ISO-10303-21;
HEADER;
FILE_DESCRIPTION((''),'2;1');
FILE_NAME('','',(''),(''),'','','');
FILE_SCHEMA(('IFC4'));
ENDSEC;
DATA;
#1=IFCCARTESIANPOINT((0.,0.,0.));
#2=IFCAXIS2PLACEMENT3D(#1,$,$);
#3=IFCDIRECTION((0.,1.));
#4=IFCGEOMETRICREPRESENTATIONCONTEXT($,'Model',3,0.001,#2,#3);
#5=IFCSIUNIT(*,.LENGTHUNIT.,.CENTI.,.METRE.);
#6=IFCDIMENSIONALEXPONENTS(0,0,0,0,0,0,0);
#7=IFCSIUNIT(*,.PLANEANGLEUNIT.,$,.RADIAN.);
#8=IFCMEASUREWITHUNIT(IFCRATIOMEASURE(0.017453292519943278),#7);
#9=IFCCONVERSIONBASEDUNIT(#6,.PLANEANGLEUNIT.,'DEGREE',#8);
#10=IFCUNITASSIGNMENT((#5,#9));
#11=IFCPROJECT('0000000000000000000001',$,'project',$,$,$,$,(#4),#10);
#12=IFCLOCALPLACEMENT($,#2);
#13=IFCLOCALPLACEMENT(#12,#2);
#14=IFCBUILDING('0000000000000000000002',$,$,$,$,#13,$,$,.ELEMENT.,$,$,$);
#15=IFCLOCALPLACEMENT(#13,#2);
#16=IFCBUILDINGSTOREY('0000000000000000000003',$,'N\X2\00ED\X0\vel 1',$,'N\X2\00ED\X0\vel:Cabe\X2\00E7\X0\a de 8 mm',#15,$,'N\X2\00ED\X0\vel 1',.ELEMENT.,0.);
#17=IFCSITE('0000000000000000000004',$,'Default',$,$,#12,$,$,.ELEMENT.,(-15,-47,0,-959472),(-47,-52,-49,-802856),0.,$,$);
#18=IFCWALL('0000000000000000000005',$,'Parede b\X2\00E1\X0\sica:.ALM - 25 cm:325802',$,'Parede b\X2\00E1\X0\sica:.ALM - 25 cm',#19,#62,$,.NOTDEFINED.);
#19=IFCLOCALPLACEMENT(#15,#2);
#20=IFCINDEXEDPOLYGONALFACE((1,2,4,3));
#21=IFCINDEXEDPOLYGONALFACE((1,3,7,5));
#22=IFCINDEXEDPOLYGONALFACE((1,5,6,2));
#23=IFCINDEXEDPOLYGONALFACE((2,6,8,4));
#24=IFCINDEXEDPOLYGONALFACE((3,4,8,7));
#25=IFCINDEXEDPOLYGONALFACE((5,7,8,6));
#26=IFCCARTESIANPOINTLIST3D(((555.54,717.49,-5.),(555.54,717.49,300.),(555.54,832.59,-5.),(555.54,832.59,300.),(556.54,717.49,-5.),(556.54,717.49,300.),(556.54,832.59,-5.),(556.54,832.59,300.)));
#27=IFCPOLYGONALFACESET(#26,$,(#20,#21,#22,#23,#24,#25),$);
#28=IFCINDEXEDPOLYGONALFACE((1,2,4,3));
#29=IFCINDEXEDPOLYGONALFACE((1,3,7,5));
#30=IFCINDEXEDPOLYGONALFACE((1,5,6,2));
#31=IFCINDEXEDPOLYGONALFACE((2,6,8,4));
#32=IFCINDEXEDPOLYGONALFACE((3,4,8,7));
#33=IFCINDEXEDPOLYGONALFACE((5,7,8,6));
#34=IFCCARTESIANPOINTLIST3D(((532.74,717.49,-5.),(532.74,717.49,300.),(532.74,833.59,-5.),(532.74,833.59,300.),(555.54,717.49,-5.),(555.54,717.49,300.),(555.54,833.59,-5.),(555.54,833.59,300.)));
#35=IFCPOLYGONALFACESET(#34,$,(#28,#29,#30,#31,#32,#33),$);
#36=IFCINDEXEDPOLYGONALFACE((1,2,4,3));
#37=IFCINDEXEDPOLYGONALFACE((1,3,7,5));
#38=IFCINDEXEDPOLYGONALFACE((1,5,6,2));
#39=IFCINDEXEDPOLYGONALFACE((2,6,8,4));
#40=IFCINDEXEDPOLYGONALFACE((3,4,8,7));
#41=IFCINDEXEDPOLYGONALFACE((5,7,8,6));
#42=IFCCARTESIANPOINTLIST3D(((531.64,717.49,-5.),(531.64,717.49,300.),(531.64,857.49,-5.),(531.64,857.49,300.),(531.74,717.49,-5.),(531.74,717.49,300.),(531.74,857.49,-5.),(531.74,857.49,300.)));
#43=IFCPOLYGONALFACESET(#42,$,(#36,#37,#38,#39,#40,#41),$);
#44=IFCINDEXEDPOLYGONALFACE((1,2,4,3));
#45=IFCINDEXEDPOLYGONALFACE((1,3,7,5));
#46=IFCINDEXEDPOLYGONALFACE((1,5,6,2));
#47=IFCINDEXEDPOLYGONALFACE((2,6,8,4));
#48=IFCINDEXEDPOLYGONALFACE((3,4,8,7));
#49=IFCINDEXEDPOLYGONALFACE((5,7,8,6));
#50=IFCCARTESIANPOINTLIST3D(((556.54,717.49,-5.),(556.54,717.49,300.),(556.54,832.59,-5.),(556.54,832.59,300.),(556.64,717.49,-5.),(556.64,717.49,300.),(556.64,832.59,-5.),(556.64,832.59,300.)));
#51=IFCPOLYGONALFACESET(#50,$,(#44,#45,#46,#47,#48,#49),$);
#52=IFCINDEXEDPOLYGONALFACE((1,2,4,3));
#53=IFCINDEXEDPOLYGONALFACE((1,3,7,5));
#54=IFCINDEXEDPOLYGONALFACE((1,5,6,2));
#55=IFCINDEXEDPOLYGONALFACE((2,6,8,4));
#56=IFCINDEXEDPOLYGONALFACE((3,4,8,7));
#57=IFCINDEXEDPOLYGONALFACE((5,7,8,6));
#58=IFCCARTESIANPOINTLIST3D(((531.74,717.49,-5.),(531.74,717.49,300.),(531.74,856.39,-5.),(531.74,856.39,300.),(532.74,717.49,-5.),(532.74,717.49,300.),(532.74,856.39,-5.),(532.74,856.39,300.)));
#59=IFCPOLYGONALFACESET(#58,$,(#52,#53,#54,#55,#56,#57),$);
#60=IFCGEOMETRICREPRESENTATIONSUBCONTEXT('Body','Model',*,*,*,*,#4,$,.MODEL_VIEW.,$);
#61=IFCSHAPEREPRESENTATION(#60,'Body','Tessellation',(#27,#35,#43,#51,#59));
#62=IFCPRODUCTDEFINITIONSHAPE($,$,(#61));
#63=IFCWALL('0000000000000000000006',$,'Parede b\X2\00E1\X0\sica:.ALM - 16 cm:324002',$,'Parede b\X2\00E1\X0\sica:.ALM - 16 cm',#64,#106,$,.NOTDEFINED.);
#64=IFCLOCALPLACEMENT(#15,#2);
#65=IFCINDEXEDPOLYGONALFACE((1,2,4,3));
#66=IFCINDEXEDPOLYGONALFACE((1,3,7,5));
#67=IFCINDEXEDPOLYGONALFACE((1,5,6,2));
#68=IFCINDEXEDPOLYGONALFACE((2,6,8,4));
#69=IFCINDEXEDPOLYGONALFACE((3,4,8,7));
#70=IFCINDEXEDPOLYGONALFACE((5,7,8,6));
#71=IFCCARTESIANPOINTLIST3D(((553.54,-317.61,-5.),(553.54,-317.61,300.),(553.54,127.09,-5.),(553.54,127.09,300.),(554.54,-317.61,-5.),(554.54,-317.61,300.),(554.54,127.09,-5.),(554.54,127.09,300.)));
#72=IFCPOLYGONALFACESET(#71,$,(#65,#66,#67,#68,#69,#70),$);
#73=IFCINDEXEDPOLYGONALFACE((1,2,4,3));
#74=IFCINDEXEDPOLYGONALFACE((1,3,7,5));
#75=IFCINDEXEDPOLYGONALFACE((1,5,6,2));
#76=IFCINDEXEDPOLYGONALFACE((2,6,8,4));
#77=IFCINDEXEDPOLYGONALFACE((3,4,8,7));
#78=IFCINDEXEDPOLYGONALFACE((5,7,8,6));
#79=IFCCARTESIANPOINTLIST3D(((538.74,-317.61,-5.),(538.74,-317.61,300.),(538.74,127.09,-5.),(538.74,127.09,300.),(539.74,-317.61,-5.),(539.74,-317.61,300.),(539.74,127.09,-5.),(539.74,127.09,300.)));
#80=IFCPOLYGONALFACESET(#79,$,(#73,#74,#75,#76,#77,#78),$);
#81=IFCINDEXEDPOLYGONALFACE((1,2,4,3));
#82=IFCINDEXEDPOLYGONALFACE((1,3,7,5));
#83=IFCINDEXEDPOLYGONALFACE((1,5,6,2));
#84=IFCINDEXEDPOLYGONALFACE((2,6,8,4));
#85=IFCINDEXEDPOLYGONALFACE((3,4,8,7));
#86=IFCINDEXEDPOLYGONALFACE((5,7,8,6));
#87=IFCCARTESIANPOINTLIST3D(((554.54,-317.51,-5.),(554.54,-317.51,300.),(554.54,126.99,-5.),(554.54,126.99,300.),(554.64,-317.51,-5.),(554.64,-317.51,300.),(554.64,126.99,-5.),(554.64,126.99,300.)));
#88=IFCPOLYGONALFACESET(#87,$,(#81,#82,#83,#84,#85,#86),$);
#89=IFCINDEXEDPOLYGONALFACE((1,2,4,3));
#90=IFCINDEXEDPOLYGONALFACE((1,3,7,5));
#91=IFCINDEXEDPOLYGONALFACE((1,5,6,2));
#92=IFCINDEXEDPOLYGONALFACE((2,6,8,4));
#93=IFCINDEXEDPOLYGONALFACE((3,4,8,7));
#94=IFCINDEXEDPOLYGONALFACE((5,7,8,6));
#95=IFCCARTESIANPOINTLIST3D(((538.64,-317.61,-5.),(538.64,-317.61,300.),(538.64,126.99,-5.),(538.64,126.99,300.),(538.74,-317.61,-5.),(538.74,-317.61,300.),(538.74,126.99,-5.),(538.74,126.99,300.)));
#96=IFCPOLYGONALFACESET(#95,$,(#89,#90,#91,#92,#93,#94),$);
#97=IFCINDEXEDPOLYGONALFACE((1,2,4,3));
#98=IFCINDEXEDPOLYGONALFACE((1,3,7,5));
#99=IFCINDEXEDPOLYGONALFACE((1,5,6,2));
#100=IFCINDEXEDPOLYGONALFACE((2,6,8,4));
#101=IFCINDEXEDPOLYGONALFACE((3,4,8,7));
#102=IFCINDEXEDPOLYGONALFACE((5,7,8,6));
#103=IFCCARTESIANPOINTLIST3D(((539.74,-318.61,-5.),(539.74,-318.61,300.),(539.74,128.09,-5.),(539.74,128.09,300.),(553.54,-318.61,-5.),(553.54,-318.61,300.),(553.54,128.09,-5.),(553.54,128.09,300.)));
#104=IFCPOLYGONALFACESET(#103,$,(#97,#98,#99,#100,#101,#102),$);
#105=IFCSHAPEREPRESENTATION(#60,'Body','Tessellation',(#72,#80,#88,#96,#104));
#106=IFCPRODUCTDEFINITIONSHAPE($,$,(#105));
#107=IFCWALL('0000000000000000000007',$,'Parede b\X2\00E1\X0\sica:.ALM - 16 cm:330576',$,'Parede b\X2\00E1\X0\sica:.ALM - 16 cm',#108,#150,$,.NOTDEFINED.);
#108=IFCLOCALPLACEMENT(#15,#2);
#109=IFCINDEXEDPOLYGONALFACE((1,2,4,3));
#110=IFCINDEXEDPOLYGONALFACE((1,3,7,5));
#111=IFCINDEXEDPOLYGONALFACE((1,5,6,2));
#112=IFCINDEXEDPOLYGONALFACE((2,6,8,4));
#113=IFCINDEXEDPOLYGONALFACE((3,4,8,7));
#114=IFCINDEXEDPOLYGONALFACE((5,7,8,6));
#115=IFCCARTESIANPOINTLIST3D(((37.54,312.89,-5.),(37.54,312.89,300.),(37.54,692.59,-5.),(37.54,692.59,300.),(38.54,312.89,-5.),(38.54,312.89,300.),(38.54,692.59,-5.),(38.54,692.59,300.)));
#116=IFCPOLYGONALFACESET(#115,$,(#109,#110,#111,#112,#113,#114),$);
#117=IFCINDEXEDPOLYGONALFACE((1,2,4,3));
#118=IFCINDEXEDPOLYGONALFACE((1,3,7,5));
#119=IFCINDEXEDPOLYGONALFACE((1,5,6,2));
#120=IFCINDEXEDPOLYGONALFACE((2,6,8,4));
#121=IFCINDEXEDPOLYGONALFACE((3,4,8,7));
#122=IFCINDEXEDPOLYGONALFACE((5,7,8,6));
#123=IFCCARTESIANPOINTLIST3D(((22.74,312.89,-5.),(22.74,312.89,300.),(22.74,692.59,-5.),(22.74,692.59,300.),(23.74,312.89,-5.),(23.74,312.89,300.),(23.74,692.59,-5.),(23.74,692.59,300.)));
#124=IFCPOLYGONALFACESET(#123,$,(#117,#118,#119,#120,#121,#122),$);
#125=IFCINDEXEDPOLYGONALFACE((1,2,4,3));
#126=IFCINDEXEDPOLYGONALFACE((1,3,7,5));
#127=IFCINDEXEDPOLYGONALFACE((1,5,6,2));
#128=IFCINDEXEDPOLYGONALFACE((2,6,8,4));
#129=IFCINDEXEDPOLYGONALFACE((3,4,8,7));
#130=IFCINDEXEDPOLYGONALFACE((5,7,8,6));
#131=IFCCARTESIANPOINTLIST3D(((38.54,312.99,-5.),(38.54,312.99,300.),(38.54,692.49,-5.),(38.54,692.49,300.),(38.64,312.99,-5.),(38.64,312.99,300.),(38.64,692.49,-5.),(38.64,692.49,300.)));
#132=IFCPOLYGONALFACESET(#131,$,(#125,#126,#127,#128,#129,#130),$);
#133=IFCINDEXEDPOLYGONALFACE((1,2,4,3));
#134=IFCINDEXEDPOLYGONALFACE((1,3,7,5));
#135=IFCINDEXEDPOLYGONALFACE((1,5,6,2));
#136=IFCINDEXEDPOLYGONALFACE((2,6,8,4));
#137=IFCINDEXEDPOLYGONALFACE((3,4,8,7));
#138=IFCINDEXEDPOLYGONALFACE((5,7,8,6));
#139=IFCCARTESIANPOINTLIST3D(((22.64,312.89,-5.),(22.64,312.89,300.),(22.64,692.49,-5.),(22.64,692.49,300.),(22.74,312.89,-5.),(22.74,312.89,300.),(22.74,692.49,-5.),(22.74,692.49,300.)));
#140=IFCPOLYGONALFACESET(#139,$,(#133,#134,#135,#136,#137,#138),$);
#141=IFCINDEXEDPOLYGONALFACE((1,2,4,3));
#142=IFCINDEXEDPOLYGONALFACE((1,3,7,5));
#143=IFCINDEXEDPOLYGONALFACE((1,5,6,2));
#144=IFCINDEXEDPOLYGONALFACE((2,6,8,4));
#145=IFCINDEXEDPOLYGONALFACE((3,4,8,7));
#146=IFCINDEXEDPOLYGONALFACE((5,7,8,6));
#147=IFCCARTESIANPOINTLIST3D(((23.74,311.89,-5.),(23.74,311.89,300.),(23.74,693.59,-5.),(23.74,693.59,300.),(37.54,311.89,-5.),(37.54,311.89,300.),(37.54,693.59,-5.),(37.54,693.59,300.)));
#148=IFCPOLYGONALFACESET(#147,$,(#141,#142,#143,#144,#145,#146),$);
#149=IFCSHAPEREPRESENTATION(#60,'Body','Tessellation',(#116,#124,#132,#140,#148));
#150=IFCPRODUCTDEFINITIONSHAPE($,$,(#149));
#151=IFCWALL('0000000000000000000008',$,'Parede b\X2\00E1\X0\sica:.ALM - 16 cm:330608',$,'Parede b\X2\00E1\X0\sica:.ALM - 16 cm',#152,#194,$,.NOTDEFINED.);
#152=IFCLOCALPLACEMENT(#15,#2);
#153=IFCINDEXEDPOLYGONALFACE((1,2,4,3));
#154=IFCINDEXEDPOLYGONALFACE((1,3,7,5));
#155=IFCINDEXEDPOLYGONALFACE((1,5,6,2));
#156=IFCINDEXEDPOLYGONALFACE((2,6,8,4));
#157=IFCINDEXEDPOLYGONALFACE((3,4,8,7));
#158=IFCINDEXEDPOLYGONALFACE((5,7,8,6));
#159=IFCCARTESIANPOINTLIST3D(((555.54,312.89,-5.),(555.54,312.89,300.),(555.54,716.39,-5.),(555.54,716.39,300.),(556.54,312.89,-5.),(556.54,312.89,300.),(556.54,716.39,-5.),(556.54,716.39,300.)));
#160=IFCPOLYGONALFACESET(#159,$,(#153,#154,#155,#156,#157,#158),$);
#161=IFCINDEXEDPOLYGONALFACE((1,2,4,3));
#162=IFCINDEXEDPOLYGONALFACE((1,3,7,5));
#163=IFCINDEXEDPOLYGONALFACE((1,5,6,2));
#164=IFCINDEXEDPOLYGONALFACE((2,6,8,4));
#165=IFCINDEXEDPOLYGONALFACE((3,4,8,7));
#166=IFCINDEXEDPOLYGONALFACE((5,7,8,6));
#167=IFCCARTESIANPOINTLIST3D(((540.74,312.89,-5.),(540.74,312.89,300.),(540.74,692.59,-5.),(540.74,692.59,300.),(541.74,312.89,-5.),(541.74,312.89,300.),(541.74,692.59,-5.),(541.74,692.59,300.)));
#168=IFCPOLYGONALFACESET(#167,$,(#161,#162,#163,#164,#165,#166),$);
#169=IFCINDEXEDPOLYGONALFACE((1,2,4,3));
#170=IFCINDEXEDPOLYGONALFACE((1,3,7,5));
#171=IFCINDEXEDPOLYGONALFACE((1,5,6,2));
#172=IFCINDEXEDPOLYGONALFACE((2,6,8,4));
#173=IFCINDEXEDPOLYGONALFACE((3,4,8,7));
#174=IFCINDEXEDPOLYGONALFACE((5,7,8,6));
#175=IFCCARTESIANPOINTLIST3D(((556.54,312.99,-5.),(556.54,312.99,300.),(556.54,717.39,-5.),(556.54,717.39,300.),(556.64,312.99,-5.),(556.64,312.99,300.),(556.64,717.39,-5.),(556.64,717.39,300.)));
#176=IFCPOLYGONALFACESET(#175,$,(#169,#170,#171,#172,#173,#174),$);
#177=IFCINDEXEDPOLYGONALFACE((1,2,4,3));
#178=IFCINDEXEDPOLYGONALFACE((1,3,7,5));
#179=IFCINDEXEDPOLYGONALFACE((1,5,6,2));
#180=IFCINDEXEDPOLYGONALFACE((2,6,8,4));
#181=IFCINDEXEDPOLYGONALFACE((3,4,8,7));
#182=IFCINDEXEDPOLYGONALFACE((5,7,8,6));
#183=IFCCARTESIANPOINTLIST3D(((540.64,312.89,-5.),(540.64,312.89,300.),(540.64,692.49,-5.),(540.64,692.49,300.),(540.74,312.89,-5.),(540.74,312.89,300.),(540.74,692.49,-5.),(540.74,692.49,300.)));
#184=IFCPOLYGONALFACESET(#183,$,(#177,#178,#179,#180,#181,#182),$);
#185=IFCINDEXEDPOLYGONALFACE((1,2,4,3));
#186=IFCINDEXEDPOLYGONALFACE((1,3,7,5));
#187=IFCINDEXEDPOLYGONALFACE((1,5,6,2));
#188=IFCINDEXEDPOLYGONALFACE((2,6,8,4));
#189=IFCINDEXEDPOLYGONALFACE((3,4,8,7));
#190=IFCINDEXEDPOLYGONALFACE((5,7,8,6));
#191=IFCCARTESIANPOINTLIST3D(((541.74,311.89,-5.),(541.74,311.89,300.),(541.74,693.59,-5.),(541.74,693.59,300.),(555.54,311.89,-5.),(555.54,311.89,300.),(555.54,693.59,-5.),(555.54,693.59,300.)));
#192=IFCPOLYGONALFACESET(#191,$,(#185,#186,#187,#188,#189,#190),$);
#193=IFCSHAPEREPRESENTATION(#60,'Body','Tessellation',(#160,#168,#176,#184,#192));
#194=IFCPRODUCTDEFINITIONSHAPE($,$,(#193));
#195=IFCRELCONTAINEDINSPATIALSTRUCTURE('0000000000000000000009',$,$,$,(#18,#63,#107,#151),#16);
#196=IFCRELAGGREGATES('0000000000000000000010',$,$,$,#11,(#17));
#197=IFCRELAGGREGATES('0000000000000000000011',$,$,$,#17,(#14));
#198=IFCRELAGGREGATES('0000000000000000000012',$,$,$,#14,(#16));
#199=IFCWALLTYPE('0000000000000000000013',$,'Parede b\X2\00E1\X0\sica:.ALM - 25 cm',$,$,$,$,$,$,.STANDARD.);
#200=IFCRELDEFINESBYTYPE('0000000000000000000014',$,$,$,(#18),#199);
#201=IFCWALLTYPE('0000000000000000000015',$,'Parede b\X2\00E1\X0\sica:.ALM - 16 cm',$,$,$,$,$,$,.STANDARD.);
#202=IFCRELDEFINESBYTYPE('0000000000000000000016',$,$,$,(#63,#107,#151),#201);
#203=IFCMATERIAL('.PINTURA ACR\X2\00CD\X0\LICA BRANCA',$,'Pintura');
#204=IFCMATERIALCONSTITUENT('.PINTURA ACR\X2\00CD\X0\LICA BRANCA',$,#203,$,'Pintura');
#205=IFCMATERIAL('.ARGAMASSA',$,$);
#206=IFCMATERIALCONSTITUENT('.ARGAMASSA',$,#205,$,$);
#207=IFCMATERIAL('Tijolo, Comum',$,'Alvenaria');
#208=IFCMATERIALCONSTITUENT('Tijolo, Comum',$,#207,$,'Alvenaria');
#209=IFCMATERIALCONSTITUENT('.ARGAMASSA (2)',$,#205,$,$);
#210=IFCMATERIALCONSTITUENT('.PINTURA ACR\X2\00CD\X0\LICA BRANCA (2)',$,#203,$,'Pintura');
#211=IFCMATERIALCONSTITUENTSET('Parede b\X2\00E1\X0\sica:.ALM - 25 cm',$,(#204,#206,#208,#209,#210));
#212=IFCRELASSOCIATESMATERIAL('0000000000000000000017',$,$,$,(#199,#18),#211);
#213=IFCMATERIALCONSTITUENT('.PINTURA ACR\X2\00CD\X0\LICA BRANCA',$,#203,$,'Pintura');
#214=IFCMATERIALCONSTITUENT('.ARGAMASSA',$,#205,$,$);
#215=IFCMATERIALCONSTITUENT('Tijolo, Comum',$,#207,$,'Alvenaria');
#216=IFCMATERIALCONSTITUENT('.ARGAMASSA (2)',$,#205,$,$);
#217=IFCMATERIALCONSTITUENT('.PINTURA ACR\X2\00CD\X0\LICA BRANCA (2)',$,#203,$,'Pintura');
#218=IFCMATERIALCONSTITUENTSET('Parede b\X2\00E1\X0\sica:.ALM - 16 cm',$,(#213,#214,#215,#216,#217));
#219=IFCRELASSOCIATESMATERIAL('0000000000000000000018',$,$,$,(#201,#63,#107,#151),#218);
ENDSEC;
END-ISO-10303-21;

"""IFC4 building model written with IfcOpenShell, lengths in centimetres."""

from ifc_helpers import new_model, entity, si_unit, converted_unit, direction, frame, origin, place, context, subcontext, project, spatial, indexed_curve, outline, extrude, material, constituent, constituent_set, type_object, element, save


model = new_model("IFC4")

# Units and contexts
model_context = context("Model", 3, precision=0.001, world=origin(), true_north=direction((0.0, 1.0)))
body_context = subcontext(model_context, "Body", "Model", "MODEL_VIEW")
ifc_project = project(units=[si_unit("LENGTHUNIT", "METRE", prefix="CENTI"), converted_unit("PLANEANGLEUNIT", "DEGREE", entity("IfcRatioMeasure", 0.017453292519943278), si_unit("PLANEANGLEUNIT", "RADIAN"), dimensions=[0, 0, 0, 0, 0, 0, 0])], contexts=[model_context])

# Site, building, storey
site_placement = place(None, origin())
site = spatial("IfcSite", under=ifc_project, at=site_placement, Name="Default", CompositionType="ELEMENT", RefLatitude=(-15, -47, 0, -959472), RefLongitude=(-47, -52, -49, -802856), RefElevation=0.0)
building_placement = place(site_placement, origin())
building = spatial("IfcBuilding", under=site, at=building_placement, CompositionType="ELEMENT")
storey_placement = place(building_placement, origin())
storey = spatial("IfcBuildingStorey", under=building, at=storey_placement, Name="Nível 1", ObjectType="Nível:Cabeça de 8 mm", LongName="Nível 1", CompositionType="ELEMENT", Elevation=0.0)

# Shared definitions
ifc_material_1 = material(Name=".PINTURA ACRÍLICA BRANCA", Category="Pintura")
ifc_constituent_1 = constituent(ifc_material_1, Name=".PINTURA ACRÍLICA BRANCA", Category="Pintura")
ifc_material_2 = material(Name=".ARGAMASSA")
ifc_constituent_2 = constituent(ifc_material_2, Name=".ARGAMASSA")
ifc_material_3 = material(Name="Tijolo, Comum", Category="Alvenaria")
ifc_constituent_3 = constituent(ifc_material_3, Name="Tijolo, Comum", Category="Alvenaria")
ifc_constituent_4 = constituent(ifc_material_2, Name=".ARGAMASSA (2)")
ifc_constituent_5 = constituent(ifc_material_1, Name=".PINTURA ACRÍLICA BRANCA (2)", Category="Pintura")
ifc_constituent_set_1 = constituent_set(constituents=[ifc_constituent_1, ifc_constituent_2, ifc_constituent_3, ifc_constituent_4, ifc_constituent_5], Name="Parede básica:.ALM - 25 cm")
wall_type_1 = type_object("IfcWallType", Name="Parede básica:.ALM - 25 cm", PredefinedType="STANDARD", material=ifc_constituent_set_1)

# Wall
wall_1_placement = place(storey_placement, frame((544.14, 717.49, -5.0), z_axis=(0.0, 0.0, 1.0), x_axis=(0.0, 1.0, 0.0)))
element("IfcWall", 1, at=wall_1_placement, inside=storey, type_object=wall_type_1, material=ifc_constituent_set_1, Name="Parede básica:.ALM - 25 cm:325802", ObjectType="Parede básica:.ALM - 25 cm", PredefinedType="NOTDEFINED", context=body_context, shape_type="SweptSolid", body=[
    extrude(outline(indexed_curve([(-57.55, -0.5), (57.55, -0.5), (57.55, 0.5), (-57.55, 0.5), (-57.55, -0.5)], self_intersect=False)), frame((57.55, -11.9, 0.0)), (0.0, 0.0, 1.0), 305.0),
    extrude(outline(indexed_curve([(-58.05, -11.4), (58.05, -11.4), (58.05, 11.4), (-58.05, 11.4), (-58.05, -11.4)], self_intersect=False)), frame((58.05, 0.0, 0.0)), (0.0, 0.0, 1.0), 305.0),
    extrude(outline(indexed_curve([(-0.05, -70.0), (0.05, -70.0), (0.05, 70.0), (-0.05, 70.0), (-0.05, -70.0)], self_intersect=False)), frame((70.0, 12.45, 0.0), z_axis=(0.0, 0.0, 1.0), x_axis=(0.0, -1.0, 0.0)), (0.0, 0.0, 1.0), 305.0),
    extrude(outline(indexed_curve([(-0.05, -57.55), (0.05, -57.55), (0.05, 57.55), (-0.05, 57.55), (-0.05, -57.55)], self_intersect=False)), frame((57.55, -12.45, 0.0), z_axis=(0.0, 0.0, 1.0), x_axis=(0.0, 1.0, 0.0)), (0.0, 0.0, 1.0), 305.0),
    extrude(outline(indexed_curve([(-69.45, -0.5), (69.45, -0.5), (69.45, 0.5), (-69.45, 0.5), (-69.45, -0.5)], self_intersect=False)), frame((69.45, 11.9, 0.0)), (0.0, 0.0, 1.0), 305.0),
])

# Shared definitions
ifc_constituent_6 = constituent(ifc_material_1, Name=".PINTURA ACRÍLICA BRANCA", Category="Pintura")
ifc_constituent_7 = constituent(ifc_material_2, Name=".ARGAMASSA")
ifc_constituent_8 = constituent(ifc_material_3, Name="Tijolo, Comum", Category="Alvenaria")
ifc_constituent_9 = constituent(ifc_material_2, Name=".ARGAMASSA (2)")
ifc_constituent_10 = constituent(ifc_material_1, Name=".PINTURA ACRÍLICA BRANCA (2)", Category="Pintura")
ifc_constituent_set_2 = constituent_set(constituents=[ifc_constituent_6, ifc_constituent_7, ifc_constituent_8, ifc_constituent_9, ifc_constituent_10], Name="Parede básica:.ALM - 16 cm")
wall_type_2 = type_object("IfcWallType", Name="Parede básica:.ALM - 16 cm", PredefinedType="STANDARD", material=ifc_constituent_set_2)

# Wall
wall_2_placement = place(storey_placement, frame((546.64, -317.51, -5.0), z_axis=(0.0, 0.0, 1.0), x_axis=(0.0, 1.0, 0.0)))
element("IfcWall", 2, at=wall_2_placement, inside=storey, type_object=wall_type_2, material=ifc_constituent_set_2, Name="Parede básica:.ALM - 16 cm:324002", ObjectType="Parede básica:.ALM - 16 cm", PredefinedType="NOTDEFINED", context=body_context, shape_type="SweptSolid", body=[
    extrude(outline(indexed_curve([(-222.35, -0.5), (222.35, -0.5), (222.35, 0.5), (-222.35, 0.5), (-222.35, -0.5)], self_intersect=False)), frame((222.25, -7.4, 0.0)), (0.0, 0.0, 1.0), 305.0),
    extrude(outline(indexed_curve([(-222.35, -0.5), (222.35, -0.5), (222.35, 0.5), (-222.35, 0.5), (-222.35, -0.5)], self_intersect=False)), frame((222.25, 7.4, 0.0)), (0.0, 0.0, 1.0), 305.0),
    extrude(outline(indexed_curve([(-0.05, -222.25), (0.05, -222.25), (0.05, 222.25), (-0.05, 222.25), (-0.05, -222.25)], self_intersect=False)), frame((222.25, -7.95, 0.0), z_axis=(0.0, 0.0, 1.0), x_axis=(0.0, 1.0, 0.0)), (0.0, 0.0, 1.0), 305.0),
    extrude(outline(indexed_curve([(-0.05, -222.3), (0.05, -222.3), (0.05, 222.3), (-0.05, 222.3), (-0.05, -222.3)], self_intersect=False)), frame((222.2, 7.95, 0.0), z_axis=(0.0, 0.0, 1.0), x_axis=(0.0, -1.0, 0.0)), (0.0, 0.0, 1.0), 305.0),
    extrude(outline(indexed_curve([(-223.35, -6.9), (223.35, -6.9), (223.35, 6.9), (-223.35, 6.9), (-223.35, -6.9)], self_intersect=False)), frame((222.25, 0.0, 0.0)), (0.0, 0.0, 1.0), 305.0),
])

# Walls
wall_3_placement = place(storey_placement, frame((30.64, 312.99, -5.0), z_axis=(0.0, 0.0, 1.0), x_axis=(0.0, 1.0, 0.0)))
element("IfcWall", 3, at=wall_3_placement, inside=storey, type_object=wall_type_2, material=ifc_constituent_set_2, Name="Parede básica:.ALM - 16 cm:330576", ObjectType="Parede básica:.ALM - 16 cm", PredefinedType="NOTDEFINED", context=body_context, shape_type="SweptSolid", body=[
    extrude(outline(indexed_curve([(-189.85, -0.5), (189.85, -0.5), (189.85, 0.5), (-189.85, 0.5), (-189.85, -0.5)], self_intersect=False)), frame((189.75, -7.4, 0.0)), (0.0, 0.0, 1.0), 305.0),
    extrude(outline(indexed_curve([(-189.85, -0.5), (189.85, -0.5), (189.85, 0.5), (-189.85, 0.5), (-189.85, -0.5)], self_intersect=False)), frame((189.75, 7.4, 0.0)), (0.0, 0.0, 1.0), 305.0),
    extrude(outline(indexed_curve([(-0.05, -189.75), (0.05, -189.75), (0.05, 189.75), (-0.05, 189.75), (-0.05, -189.75)], self_intersect=False)), frame((189.75, -7.95, 0.0), z_axis=(0.0, 0.0, 1.0), x_axis=(0.0, 1.0, 0.0)), (0.0, 0.0, 1.0), 305.0),
    extrude(outline(indexed_curve([(-0.05, -189.8), (0.05, -189.8), (0.05, 189.8), (-0.05, 189.8), (-0.05, -189.8)], self_intersect=False)), frame((189.7, 7.95, 0.0), z_axis=(0.0, 0.0, 1.0), x_axis=(0.0, -1.0, 0.0)), (0.0, 0.0, 1.0), 305.0),
    extrude(outline(indexed_curve([(-190.85, -6.9), (190.85, -6.9), (190.85, 6.9), (-190.85, 6.9), (-190.85, -6.9)], self_intersect=False)), frame((189.75, 0.0, 0.0)), (0.0, 0.0, 1.0), 305.0),
])
wall_4_placement = place(storey_placement, frame((548.64, 312.99, -5.0), z_axis=(0.0, 0.0, 1.0), x_axis=(0.0, 1.0, 0.0)))
element("IfcWall", 4, at=wall_4_placement, inside=storey, type_object=wall_type_2, material=ifc_constituent_set_2, Name="Parede básica:.ALM - 16 cm:330608", ObjectType="Parede básica:.ALM - 16 cm", PredefinedType="NOTDEFINED", context=body_context, shape_type="SweptSolid", body=[
    extrude(outline(indexed_curve([(-201.75, -0.5), (201.75, -0.5), (201.75, 0.5), (-201.75, 0.5), (-201.75, -0.5)], self_intersect=False)), frame((201.65, -7.4, 0.0)), (0.0, 0.0, 1.0), 305.0),
    extrude(outline(indexed_curve([(-189.85, -0.5), (189.85, -0.5), (189.85, 0.5), (-189.85, 0.5), (-189.85, -0.5)], self_intersect=False)), frame((189.75, 7.4, 0.0)), (0.0, 0.0, 1.0), 305.0),
    extrude(outline(indexed_curve([(-0.05, -202.2), (0.05, -202.2), (0.05, 202.2), (-0.05, 202.2), (-0.05, -202.2)], self_intersect=False)), frame((202.2, -7.95, 0.0), z_axis=(0.0, 0.0, 1.0), x_axis=(0.0, 1.0, 0.0)), (0.0, 0.0, 1.0), 305.0),
    extrude(outline(indexed_curve([(-0.05, -189.8), (0.05, -189.8), (0.05, 189.8), (-0.05, 189.8), (-0.05, -189.8)], self_intersect=False)), frame((189.7, 7.95, 0.0), z_axis=(0.0, 0.0, 1.0), x_axis=(0.0, -1.0, 0.0)), (0.0, 0.0, 1.0), 305.0),
    extrude(outline(indexed_curve([(-190.85, -6.9), (190.85, -6.9), (190.85, 6.9), (-190.85, 6.9), (-190.85, -6.9)], self_intersect=False)), frame((189.75, 0.0, 0.0)), (0.0, 0.0, 1.0), 305.0),
])

save(model, "model.ifc")
